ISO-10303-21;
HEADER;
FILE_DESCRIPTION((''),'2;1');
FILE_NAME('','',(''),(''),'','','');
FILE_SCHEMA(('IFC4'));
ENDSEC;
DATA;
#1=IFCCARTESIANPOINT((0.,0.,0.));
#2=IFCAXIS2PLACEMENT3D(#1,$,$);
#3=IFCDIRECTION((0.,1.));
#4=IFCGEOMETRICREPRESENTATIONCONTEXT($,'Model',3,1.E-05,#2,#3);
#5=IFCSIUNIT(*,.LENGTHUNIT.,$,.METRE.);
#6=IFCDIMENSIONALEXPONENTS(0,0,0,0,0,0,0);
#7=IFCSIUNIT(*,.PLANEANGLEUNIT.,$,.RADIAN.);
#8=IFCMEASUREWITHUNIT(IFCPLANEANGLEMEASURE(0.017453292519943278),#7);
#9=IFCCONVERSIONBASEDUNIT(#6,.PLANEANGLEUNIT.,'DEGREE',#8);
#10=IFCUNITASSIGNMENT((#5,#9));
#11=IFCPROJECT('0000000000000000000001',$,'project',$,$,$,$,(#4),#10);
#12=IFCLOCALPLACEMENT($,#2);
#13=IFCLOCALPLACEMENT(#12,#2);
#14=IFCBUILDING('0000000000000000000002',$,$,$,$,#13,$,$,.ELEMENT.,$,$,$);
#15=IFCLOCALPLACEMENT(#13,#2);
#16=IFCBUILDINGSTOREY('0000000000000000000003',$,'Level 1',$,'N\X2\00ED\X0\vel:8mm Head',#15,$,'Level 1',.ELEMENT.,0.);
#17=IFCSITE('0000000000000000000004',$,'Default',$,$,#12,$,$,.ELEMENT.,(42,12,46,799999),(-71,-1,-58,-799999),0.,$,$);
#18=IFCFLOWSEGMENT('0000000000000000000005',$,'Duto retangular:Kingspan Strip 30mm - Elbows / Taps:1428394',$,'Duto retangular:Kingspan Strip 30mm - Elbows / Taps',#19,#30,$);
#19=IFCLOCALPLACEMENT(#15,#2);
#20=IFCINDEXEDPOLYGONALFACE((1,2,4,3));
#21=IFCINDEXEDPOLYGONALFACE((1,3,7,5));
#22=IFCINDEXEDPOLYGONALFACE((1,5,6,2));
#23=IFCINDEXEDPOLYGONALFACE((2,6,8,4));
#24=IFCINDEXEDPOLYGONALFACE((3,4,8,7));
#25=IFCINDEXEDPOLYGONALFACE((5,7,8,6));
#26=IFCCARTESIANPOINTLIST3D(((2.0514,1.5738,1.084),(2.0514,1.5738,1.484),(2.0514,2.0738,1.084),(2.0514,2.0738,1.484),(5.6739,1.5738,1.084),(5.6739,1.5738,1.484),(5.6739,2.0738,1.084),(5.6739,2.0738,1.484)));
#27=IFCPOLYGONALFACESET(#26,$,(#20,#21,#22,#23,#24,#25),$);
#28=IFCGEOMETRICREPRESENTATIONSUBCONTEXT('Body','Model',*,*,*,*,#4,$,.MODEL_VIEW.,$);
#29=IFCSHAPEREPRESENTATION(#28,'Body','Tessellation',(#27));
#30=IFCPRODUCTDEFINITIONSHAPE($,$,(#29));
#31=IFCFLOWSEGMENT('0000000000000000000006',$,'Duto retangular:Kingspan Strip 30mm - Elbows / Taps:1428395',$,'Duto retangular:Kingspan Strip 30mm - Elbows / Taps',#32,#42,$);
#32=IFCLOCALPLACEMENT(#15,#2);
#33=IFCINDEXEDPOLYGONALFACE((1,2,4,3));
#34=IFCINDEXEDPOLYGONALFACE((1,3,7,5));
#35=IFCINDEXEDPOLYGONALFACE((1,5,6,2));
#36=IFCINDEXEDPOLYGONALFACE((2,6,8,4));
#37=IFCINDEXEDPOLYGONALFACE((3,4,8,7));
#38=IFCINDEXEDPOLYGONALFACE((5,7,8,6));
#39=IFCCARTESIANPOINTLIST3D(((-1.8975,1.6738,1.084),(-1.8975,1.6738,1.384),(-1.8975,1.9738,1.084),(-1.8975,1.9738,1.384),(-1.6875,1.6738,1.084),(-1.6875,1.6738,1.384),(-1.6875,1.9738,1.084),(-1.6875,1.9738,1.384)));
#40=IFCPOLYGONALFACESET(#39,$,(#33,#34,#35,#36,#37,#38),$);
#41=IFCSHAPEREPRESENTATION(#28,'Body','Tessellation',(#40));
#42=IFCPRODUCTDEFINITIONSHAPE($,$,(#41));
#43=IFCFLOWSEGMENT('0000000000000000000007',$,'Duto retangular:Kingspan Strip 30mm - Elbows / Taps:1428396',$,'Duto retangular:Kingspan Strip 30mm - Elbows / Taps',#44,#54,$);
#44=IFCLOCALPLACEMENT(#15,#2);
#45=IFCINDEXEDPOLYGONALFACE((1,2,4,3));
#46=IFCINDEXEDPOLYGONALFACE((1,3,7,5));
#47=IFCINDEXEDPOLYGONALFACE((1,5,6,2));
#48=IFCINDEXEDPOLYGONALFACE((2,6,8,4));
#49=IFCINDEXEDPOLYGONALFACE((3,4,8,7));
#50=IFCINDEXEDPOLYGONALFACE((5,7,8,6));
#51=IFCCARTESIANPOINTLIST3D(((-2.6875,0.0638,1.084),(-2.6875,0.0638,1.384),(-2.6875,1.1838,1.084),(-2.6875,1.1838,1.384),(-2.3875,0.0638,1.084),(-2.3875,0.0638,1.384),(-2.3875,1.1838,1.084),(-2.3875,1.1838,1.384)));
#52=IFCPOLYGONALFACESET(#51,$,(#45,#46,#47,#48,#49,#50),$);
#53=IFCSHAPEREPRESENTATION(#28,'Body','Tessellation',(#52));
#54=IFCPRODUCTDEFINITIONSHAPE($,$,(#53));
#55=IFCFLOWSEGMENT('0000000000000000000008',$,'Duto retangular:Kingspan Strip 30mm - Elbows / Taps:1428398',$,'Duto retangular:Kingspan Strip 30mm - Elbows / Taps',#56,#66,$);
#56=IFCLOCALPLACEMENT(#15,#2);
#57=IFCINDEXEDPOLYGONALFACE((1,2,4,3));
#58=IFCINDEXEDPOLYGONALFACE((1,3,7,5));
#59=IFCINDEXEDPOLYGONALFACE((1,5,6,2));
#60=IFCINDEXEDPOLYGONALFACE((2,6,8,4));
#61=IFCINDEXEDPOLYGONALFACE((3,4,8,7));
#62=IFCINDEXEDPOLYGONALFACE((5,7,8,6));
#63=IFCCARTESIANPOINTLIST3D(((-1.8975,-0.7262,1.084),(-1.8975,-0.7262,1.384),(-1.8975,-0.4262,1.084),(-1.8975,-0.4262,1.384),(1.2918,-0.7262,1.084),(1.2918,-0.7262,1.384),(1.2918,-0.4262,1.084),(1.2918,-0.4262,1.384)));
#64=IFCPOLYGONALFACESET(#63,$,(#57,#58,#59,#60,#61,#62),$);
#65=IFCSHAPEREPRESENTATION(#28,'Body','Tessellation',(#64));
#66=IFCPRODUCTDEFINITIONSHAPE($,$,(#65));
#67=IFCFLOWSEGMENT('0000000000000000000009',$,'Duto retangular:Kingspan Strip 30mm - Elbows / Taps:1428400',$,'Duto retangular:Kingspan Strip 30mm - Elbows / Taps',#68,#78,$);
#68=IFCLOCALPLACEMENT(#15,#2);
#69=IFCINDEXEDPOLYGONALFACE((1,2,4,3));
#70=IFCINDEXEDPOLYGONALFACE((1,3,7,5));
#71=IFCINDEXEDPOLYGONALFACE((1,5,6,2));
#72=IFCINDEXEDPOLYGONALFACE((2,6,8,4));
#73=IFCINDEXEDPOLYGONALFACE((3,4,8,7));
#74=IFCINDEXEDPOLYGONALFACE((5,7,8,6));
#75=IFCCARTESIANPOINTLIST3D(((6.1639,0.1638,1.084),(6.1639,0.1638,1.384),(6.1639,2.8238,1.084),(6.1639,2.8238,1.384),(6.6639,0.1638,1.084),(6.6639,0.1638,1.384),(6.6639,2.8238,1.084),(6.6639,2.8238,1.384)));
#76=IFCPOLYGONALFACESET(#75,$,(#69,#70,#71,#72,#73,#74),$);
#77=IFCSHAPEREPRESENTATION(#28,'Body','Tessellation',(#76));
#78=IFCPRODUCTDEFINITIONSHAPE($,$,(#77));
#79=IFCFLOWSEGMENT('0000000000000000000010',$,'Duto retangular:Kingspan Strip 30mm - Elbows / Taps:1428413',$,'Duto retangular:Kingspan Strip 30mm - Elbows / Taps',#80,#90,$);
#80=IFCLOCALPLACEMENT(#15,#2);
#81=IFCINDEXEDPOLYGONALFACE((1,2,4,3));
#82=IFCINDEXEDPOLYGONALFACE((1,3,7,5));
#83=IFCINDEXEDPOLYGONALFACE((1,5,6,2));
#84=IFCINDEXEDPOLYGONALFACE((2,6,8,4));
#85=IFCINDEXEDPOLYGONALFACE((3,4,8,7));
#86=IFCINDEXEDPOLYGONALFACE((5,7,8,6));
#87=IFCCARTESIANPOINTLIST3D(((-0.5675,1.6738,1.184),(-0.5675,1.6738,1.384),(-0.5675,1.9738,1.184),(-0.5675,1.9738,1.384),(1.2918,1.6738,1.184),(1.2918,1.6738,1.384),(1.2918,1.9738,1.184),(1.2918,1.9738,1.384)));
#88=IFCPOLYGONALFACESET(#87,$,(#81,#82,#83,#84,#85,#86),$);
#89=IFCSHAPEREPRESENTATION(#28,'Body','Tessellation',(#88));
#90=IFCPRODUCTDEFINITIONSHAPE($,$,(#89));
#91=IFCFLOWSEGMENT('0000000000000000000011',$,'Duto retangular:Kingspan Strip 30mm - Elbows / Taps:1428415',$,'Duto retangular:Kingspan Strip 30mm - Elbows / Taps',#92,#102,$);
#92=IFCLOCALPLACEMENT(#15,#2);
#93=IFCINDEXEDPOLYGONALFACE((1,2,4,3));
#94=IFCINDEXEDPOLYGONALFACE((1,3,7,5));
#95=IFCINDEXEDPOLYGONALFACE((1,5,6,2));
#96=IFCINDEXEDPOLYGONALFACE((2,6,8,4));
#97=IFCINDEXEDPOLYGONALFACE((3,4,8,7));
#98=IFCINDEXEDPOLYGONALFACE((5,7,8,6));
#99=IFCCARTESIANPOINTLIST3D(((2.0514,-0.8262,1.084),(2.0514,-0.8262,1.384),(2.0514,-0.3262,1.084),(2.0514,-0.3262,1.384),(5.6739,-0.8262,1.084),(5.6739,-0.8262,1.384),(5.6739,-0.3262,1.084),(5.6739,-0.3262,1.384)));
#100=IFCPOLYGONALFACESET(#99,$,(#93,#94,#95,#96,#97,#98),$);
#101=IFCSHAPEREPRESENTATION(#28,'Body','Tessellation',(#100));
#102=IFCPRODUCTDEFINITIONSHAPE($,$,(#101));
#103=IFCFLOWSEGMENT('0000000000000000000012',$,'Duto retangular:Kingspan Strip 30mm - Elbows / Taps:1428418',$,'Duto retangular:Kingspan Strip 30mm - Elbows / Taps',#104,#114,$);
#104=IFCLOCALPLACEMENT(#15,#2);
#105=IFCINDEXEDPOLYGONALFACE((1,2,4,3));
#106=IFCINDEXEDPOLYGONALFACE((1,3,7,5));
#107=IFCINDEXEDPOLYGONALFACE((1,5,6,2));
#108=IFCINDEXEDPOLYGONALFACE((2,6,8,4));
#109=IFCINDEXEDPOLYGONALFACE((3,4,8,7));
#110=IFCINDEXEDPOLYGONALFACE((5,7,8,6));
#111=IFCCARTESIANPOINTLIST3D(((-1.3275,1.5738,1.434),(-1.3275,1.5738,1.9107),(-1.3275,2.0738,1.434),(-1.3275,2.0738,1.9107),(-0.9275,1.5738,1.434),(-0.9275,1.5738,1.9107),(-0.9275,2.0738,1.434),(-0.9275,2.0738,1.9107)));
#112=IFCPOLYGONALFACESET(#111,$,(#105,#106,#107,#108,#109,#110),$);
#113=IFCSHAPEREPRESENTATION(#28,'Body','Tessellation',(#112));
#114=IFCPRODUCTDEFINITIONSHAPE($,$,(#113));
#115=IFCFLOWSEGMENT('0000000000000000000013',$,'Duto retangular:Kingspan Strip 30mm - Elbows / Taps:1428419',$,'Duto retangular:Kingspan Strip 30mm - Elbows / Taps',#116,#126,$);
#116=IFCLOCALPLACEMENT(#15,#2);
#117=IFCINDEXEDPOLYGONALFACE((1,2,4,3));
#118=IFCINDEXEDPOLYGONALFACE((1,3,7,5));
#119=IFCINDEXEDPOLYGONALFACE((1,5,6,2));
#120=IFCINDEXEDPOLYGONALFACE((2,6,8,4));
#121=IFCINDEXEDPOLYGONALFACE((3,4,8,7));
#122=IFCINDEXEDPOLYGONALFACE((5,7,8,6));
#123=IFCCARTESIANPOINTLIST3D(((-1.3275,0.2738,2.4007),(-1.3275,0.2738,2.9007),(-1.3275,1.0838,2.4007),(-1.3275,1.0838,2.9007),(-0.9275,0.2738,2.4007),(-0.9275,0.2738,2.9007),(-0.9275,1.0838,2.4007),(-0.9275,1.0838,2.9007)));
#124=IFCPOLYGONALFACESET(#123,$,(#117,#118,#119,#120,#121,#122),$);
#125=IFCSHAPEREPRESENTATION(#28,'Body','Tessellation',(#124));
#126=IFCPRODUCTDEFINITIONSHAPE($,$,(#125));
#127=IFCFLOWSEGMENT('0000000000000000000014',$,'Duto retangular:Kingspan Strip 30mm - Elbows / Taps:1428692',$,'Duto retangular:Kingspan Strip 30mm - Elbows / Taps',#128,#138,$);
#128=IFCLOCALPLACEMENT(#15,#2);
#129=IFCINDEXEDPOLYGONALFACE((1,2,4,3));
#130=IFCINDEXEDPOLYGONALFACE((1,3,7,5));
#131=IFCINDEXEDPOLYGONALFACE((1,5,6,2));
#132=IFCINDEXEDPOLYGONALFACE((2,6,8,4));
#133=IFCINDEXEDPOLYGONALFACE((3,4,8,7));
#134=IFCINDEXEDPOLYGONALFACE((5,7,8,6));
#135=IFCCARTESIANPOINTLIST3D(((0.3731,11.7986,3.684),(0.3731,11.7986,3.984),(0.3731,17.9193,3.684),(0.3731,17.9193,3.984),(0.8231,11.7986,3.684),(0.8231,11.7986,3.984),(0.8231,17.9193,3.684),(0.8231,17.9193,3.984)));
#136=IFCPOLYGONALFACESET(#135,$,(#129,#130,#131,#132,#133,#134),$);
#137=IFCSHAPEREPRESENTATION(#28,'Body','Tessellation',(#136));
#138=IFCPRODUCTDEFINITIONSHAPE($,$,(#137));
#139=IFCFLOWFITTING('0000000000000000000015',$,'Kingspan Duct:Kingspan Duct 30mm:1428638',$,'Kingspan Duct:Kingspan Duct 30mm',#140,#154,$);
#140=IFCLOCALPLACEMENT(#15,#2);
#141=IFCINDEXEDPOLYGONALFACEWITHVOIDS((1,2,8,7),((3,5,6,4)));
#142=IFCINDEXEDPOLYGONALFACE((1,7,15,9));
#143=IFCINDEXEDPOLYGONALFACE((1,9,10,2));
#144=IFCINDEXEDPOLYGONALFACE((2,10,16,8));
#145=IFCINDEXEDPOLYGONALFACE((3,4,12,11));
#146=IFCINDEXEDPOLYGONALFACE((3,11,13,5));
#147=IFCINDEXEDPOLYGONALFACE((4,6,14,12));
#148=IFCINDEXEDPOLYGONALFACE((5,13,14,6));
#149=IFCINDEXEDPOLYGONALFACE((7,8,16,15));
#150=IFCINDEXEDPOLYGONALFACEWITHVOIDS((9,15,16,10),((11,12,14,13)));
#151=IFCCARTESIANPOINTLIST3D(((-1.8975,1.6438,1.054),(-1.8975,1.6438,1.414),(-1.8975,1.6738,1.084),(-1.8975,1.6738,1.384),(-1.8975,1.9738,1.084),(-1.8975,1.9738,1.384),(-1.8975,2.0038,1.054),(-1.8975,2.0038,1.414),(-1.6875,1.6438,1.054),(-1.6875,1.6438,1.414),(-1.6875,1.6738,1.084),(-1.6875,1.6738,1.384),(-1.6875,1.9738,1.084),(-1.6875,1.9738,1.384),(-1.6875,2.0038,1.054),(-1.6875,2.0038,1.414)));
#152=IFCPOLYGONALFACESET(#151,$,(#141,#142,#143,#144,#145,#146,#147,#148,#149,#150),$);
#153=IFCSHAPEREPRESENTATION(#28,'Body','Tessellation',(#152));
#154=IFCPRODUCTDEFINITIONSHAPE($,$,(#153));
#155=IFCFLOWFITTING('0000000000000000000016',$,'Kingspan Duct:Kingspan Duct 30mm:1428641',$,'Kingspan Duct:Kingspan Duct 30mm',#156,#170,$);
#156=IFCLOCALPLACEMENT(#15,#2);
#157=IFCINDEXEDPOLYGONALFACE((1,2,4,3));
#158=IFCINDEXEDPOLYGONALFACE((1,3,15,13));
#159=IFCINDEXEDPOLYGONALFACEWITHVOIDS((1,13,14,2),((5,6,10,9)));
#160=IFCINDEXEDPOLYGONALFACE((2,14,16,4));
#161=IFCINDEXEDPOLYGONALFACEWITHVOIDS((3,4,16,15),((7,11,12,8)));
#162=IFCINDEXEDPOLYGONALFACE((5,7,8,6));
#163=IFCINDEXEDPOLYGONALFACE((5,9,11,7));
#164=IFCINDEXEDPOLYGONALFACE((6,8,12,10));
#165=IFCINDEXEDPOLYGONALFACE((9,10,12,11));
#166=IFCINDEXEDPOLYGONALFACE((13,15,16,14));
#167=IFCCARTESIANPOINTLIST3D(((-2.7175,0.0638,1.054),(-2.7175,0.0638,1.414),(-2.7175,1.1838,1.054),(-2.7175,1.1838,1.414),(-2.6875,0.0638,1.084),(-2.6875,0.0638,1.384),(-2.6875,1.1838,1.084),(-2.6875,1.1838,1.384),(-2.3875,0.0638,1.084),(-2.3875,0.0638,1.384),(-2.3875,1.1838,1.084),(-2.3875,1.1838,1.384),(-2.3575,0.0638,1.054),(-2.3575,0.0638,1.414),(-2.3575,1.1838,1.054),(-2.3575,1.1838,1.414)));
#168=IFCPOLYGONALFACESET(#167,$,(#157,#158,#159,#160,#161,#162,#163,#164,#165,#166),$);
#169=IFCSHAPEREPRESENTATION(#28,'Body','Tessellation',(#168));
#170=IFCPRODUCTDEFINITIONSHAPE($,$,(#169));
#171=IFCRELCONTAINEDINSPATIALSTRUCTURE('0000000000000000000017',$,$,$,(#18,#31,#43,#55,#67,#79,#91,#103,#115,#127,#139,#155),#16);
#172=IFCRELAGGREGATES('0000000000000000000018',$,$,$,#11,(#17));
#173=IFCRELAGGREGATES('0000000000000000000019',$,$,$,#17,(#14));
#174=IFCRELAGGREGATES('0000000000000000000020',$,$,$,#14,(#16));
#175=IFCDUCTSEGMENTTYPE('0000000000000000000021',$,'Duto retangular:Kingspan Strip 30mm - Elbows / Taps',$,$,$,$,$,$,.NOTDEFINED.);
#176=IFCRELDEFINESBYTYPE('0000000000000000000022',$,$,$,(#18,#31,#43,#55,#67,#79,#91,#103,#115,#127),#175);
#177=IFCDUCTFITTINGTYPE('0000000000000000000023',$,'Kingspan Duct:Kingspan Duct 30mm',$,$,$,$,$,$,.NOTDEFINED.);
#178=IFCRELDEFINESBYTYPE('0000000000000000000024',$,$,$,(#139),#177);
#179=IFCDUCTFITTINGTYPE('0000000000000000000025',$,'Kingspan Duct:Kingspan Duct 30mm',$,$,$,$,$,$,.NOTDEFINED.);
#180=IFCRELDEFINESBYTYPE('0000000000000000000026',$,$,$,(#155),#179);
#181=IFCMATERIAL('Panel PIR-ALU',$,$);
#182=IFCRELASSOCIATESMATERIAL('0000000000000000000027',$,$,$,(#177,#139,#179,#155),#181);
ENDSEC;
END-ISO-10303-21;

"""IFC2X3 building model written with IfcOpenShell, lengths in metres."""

from ifc_helpers import new_model, entity, si_unit, converted_unit, direction, frame, frame_2d, origin, origin_2d_with_axis, place, context, subcontext, project, spatial, polyline, rectangle, outline, extrude, source, transform, mapped, material, type_object, type_shapes, element, save


model = new_model("IFC2X3")

# Units and contexts
model_context = context("Model", 3, precision=1e-05, world=origin(), true_north=direction((0.0, 1.0)))
body_context = subcontext(model_context, "Body", "Model", "MODEL_VIEW")
ifc_project = project(units=[si_unit("LENGTHUNIT", "METRE"), converted_unit("PLANEANGLEUNIT", "DEGREE", entity("IfcPlaneAngleMeasure", 0.017453292519943278), si_unit("PLANEANGLEUNIT", "RADIAN"), dimensions=[0, 0, 0, 0, 0, 0, 0])], contexts=[model_context])

# Site, building, storey
site_placement = place(None, origin())
site = spatial("IfcSite", under=ifc_project, at=site_placement, Name="Default", CompositionType="ELEMENT", RefLatitude=(42, 12, 46, 799999), RefLongitude=(-71, -1, -58, -799999), RefElevation=0.0)
building_placement = place(site_placement, origin())
building = spatial("IfcBuilding", under=site, at=building_placement, CompositionType="ELEMENT")
storey_placement = place(building_placement, origin())
storey = spatial("IfcBuildingStorey", under=building, at=storey_placement, Name="Level 1", ObjectType="Nível:8mm Head", LongName="Level 1", CompositionType="ELEMENT", Elevation=0.0)

# Flow segments
duct_segment_type = type_object("IfcDuctSegmentType", Name="Duto retangular:Kingspan Strip 30mm - Elbows / Taps", PredefinedType="NOTDEFINED")
flow_segment_1_placement = place(storey_placement, origin())
element("IfcFlowSegment", 1, at=flow_segment_1_placement, inside=storey, type_object=duct_segment_type, Name="Duto retangular:Kingspan Strip 30mm - Elbows / Taps:1428394", ObjectType="Duto retangular:Kingspan Strip 30mm - Elbows / Taps", context=body_context, shape_type="SweptSolid", body=[
    extrude(rectangle(XDim=3.6226, YDim=0.5, at=frame_2d((0.0, 0.0), x_axis=(1.0, 0.0))), frame((3.8626, 1.8238, 1.084)), (0.0, 0.0, 1.0), 0.4),
])
flow_segment_2_placement = place(storey_placement, origin())
element("IfcFlowSegment", 2, at=flow_segment_2_placement, inside=storey, type_object=duct_segment_type, Name="Duto retangular:Kingspan Strip 30mm - Elbows / Taps:1428395", ObjectType="Duto retangular:Kingspan Strip 30mm - Elbows / Taps", context=body_context, shape_type="SweptSolid", body=[
    extrude(rectangle(XDim=0.21, YDim=0.3, at=frame_2d((0.0, 0.0), x_axis=(1.0, 0.0))), frame((-1.7925, 1.8238, 1.084), z_axis=(0.0, 0.0, 1.0), x_axis=(-1.0, 0.0, 0.0)), (0.0, 0.0, 1.0), 0.3),
])
flow_segment_3_placement = place(storey_placement, origin())
element("IfcFlowSegment", 3, at=flow_segment_3_placement, inside=storey, type_object=duct_segment_type, Name="Duto retangular:Kingspan Strip 30mm - Elbows / Taps:1428396", ObjectType="Duto retangular:Kingspan Strip 30mm - Elbows / Taps", context=body_context, shape_type="SweptSolid", body=[
    extrude(rectangle(XDim=1.12, YDim=0.3, at=frame_2d((0.0, 0.0), x_axis=(1.0, 0.0))), frame((-2.5375, 0.6238, 1.084), z_axis=(0.0, 0.0, 1.0), x_axis=(0.0, -1.0, 0.0)), (0.0, 0.0, 1.0), 0.3),
])
flow_segment_4_placement = place(storey_placement, origin())
element("IfcFlowSegment", 4, at=flow_segment_4_placement, inside=storey, type_object=duct_segment_type, Name="Duto retangular:Kingspan Strip 30mm - Elbows / Taps:1428398", ObjectType="Duto retangular:Kingspan Strip 30mm - Elbows / Taps", context=body_context, shape_type="SweptSolid", body=[
    extrude(rectangle(XDim=3.1893, YDim=0.3, at=frame_2d((0.0, 0.0), x_axis=(1.0, 0.0))), frame((-0.3029, -0.5762, 1.084)), (0.0, 0.0, 1.0), 0.3),
])
flow_segment_5_placement = place(storey_placement, origin())
element("IfcFlowSegment", 5, at=flow_segment_5_placement, inside=storey, type_object=duct_segment_type, Name="Duto retangular:Kingspan Strip 30mm - Elbows / Taps:1428400", ObjectType="Duto retangular:Kingspan Strip 30mm - Elbows / Taps", context=body_context, shape_type="SweptSolid", body=[
    extrude(rectangle(XDim=2.66, YDim=0.5, at=frame_2d((0.0, 0.0), x_axis=(1.0, 0.0))), frame((6.4139, 1.4938, 1.084), z_axis=(0.0, 0.0, 1.0), x_axis=(0.0, 1.0, 0.0)), (0.0, 0.0, 1.0), 0.3),
])
flow_segment_6_placement = place(storey_placement, origin())
element("IfcFlowSegment", 6, at=flow_segment_6_placement, inside=storey, type_object=duct_segment_type, Name="Duto retangular:Kingspan Strip 30mm - Elbows / Taps:1428413", ObjectType="Duto retangular:Kingspan Strip 30mm - Elbows / Taps", context=body_context, shape_type="SweptSolid", body=[
    extrude(rectangle(XDim=1.8593, YDim=0.3, at=origin_2d_with_axis()), frame((0.3621, 1.8238, 1.184), z_axis=(0.0, 0.0, 1.0), x_axis=(-1.0, 0.0, 0.0)), (0.0, 0.0, 1.0), 0.2),
])
flow_segment_7_placement = place(storey_placement, origin())
element("IfcFlowSegment", 7, at=flow_segment_7_placement, inside=storey, type_object=duct_segment_type, Name="Duto retangular:Kingspan Strip 30mm - Elbows / Taps:1428415", ObjectType="Duto retangular:Kingspan Strip 30mm - Elbows / Taps", context=body_context, shape_type="SweptSolid", body=[
    extrude(rectangle(XDim=3.6225, YDim=0.5, at=frame_2d((0.0, 0.0), x_axis=(1.0, 0.0))), frame((3.8626, -0.5762, 1.084)), (0.0, 0.0, 1.0), 0.3),
])
flow_segment_8_placement = place(storey_placement, origin())
element("IfcFlowSegment", 8, at=flow_segment_8_placement, inside=storey, type_object=duct_segment_type, Name="Duto retangular:Kingspan Strip 30mm - Elbows / Taps:1428418", ObjectType="Duto retangular:Kingspan Strip 30mm - Elbows / Taps", context=body_context, shape_type="SweptSolid", body=[
    extrude(rectangle(XDim=0.5, YDim=0.4, at=frame_2d((0.0, 0.0), x_axis=(1.0, 0.0))), frame((-1.1275, 1.8238, 1.434), z_axis=(0.0, 0.0, 1.0), x_axis=(0.0, -1.0, 0.0)), (0.0, 0.0, 1.0), 0.4767),
])
flow_segment_9_placement = place(storey_placement, origin())
element("IfcFlowSegment", 9, at=flow_segment_9_placement, inside=storey, type_object=duct_segment_type, Name="Duto retangular:Kingspan Strip 30mm - Elbows / Taps:1428419", ObjectType="Duto retangular:Kingspan Strip 30mm - Elbows / Taps", context=body_context, shape_type="SweptSolid", body=[
    extrude(rectangle(XDim=0.81, YDim=0.4, at=origin_2d_with_axis()), frame((-1.1275, 0.6788, 2.4007), z_axis=(0.0, 0.0, 1.0), x_axis=(0.0, -1.0, 0.0)), (0.0, 0.0, 1.0), 0.5),
])
flow_segment_10_placement = place(storey_placement, origin())
element("IfcFlowSegment", 10, at=flow_segment_10_placement, inside=storey, type_object=duct_segment_type, Name="Duto retangular:Kingspan Strip 30mm - Elbows / Taps:1428692", ObjectType="Duto retangular:Kingspan Strip 30mm - Elbows / Taps", context=body_context, shape_type="SweptSolid", body=[
    extrude(rectangle(XDim=6.1206, YDim=0.45, at=origin_2d_with_axis()), frame((0.5981, 14.8589, 3.684), z_axis=(0.0, 0.0, 1.0), x_axis=(0.0, -1.0, 0.0)), (0.0, 0.0, 1.0), 0.3),
])

# Flow fittings
ifc_material = material(Name="Panel PIR-ALU")
duct_fitting_type_1 = type_object("IfcDuctFittingType", Name="Kingspan Duct:Kingspan Duct 30mm", PredefinedType="NOTDEFINED", material=ifc_material)
shared_shape_1 = source(origin(), body_context, "Body", "SweptSolid", [
    extrude(outline(polyline([(-0.18, -0.18), (0.18, -0.18), (0.18, 0.18), (-0.18, 0.18), (-0.18, -0.18)]), holes=[polyline([(-0.15, -0.15), (-0.15, 0.15), (0.15, 0.15), (0.15, -0.15), (-0.15, -0.15)])]), frame((0.0, 0.0, -0.15), z_axis=(1.0, 0.0, 0.0), x_axis=(0.0, -1.0, 0.0)), (0.0, 0.0, 1.0), 0.21),
])
type_shapes(duct_fitting_type_1, [shared_shape_1])
flow_fitting_1_placement = place(storey_placement, frame((-1.6875, 1.8238, 1.084), z_axis=(0.0, 0.0, -1.0), x_axis=(-1.0, 0.0, 0.0)))
element("IfcFlowFitting", 11, at=flow_fitting_1_placement, inside=storey, type_object=duct_fitting_type_1, material=ifc_material, Name="Kingspan Duct:Kingspan Duct 30mm:1428638", ObjectType="Kingspan Duct:Kingspan Duct 30mm", context=body_context, shape_type="MappedRepresentation", body=[
    mapped(shared_shape_1, transform((0.0, 0.0, 0.0), scale=1.0)),
])
duct_fitting_type_2 = type_object("IfcDuctFittingType", Name="Kingspan Duct:Kingspan Duct 30mm", PredefinedType="NOTDEFINED", material=ifc_material)
shared_shape_2 = source(origin(), body_context, "Body", "SweptSolid", [
    extrude(outline(polyline([(-0.18, -0.18), (0.18, -0.18), (0.18, 0.18), (-0.18, 0.18), (-0.18, -0.18)]), holes=[polyline([(-0.15, -0.15), (-0.15, 0.15), (0.15, 0.15), (0.15, -0.15), (-0.15, -0.15)])]), frame((0.0, 0.0, -0.15), z_axis=(1.0, 0.0, 0.0), x_axis=(0.0, -1.0, 0.0)), (0.0, 0.0, 1.0), 1.12),
])
type_shapes(duct_fitting_type_2, [shared_shape_2])
flow_fitting_2_placement = place(storey_placement, frame((-2.5375, 1.1838, 1.084), z_axis=(0.0, 0.0, -1.0), x_axis=(0.0, -1.0, 0.0)))
element("IfcFlowFitting", 12, at=flow_fitting_2_placement, inside=storey, type_object=duct_fitting_type_2, material=ifc_material, Name="Kingspan Duct:Kingspan Duct 30mm:1428641", ObjectType="Kingspan Duct:Kingspan Duct 30mm", context=body_context, shape_type="MappedRepresentation", body=[
    mapped(shared_shape_2, transform((0.0, 0.0, 0.0), scale=1.0)),
])

save(model, "model.ifc")
